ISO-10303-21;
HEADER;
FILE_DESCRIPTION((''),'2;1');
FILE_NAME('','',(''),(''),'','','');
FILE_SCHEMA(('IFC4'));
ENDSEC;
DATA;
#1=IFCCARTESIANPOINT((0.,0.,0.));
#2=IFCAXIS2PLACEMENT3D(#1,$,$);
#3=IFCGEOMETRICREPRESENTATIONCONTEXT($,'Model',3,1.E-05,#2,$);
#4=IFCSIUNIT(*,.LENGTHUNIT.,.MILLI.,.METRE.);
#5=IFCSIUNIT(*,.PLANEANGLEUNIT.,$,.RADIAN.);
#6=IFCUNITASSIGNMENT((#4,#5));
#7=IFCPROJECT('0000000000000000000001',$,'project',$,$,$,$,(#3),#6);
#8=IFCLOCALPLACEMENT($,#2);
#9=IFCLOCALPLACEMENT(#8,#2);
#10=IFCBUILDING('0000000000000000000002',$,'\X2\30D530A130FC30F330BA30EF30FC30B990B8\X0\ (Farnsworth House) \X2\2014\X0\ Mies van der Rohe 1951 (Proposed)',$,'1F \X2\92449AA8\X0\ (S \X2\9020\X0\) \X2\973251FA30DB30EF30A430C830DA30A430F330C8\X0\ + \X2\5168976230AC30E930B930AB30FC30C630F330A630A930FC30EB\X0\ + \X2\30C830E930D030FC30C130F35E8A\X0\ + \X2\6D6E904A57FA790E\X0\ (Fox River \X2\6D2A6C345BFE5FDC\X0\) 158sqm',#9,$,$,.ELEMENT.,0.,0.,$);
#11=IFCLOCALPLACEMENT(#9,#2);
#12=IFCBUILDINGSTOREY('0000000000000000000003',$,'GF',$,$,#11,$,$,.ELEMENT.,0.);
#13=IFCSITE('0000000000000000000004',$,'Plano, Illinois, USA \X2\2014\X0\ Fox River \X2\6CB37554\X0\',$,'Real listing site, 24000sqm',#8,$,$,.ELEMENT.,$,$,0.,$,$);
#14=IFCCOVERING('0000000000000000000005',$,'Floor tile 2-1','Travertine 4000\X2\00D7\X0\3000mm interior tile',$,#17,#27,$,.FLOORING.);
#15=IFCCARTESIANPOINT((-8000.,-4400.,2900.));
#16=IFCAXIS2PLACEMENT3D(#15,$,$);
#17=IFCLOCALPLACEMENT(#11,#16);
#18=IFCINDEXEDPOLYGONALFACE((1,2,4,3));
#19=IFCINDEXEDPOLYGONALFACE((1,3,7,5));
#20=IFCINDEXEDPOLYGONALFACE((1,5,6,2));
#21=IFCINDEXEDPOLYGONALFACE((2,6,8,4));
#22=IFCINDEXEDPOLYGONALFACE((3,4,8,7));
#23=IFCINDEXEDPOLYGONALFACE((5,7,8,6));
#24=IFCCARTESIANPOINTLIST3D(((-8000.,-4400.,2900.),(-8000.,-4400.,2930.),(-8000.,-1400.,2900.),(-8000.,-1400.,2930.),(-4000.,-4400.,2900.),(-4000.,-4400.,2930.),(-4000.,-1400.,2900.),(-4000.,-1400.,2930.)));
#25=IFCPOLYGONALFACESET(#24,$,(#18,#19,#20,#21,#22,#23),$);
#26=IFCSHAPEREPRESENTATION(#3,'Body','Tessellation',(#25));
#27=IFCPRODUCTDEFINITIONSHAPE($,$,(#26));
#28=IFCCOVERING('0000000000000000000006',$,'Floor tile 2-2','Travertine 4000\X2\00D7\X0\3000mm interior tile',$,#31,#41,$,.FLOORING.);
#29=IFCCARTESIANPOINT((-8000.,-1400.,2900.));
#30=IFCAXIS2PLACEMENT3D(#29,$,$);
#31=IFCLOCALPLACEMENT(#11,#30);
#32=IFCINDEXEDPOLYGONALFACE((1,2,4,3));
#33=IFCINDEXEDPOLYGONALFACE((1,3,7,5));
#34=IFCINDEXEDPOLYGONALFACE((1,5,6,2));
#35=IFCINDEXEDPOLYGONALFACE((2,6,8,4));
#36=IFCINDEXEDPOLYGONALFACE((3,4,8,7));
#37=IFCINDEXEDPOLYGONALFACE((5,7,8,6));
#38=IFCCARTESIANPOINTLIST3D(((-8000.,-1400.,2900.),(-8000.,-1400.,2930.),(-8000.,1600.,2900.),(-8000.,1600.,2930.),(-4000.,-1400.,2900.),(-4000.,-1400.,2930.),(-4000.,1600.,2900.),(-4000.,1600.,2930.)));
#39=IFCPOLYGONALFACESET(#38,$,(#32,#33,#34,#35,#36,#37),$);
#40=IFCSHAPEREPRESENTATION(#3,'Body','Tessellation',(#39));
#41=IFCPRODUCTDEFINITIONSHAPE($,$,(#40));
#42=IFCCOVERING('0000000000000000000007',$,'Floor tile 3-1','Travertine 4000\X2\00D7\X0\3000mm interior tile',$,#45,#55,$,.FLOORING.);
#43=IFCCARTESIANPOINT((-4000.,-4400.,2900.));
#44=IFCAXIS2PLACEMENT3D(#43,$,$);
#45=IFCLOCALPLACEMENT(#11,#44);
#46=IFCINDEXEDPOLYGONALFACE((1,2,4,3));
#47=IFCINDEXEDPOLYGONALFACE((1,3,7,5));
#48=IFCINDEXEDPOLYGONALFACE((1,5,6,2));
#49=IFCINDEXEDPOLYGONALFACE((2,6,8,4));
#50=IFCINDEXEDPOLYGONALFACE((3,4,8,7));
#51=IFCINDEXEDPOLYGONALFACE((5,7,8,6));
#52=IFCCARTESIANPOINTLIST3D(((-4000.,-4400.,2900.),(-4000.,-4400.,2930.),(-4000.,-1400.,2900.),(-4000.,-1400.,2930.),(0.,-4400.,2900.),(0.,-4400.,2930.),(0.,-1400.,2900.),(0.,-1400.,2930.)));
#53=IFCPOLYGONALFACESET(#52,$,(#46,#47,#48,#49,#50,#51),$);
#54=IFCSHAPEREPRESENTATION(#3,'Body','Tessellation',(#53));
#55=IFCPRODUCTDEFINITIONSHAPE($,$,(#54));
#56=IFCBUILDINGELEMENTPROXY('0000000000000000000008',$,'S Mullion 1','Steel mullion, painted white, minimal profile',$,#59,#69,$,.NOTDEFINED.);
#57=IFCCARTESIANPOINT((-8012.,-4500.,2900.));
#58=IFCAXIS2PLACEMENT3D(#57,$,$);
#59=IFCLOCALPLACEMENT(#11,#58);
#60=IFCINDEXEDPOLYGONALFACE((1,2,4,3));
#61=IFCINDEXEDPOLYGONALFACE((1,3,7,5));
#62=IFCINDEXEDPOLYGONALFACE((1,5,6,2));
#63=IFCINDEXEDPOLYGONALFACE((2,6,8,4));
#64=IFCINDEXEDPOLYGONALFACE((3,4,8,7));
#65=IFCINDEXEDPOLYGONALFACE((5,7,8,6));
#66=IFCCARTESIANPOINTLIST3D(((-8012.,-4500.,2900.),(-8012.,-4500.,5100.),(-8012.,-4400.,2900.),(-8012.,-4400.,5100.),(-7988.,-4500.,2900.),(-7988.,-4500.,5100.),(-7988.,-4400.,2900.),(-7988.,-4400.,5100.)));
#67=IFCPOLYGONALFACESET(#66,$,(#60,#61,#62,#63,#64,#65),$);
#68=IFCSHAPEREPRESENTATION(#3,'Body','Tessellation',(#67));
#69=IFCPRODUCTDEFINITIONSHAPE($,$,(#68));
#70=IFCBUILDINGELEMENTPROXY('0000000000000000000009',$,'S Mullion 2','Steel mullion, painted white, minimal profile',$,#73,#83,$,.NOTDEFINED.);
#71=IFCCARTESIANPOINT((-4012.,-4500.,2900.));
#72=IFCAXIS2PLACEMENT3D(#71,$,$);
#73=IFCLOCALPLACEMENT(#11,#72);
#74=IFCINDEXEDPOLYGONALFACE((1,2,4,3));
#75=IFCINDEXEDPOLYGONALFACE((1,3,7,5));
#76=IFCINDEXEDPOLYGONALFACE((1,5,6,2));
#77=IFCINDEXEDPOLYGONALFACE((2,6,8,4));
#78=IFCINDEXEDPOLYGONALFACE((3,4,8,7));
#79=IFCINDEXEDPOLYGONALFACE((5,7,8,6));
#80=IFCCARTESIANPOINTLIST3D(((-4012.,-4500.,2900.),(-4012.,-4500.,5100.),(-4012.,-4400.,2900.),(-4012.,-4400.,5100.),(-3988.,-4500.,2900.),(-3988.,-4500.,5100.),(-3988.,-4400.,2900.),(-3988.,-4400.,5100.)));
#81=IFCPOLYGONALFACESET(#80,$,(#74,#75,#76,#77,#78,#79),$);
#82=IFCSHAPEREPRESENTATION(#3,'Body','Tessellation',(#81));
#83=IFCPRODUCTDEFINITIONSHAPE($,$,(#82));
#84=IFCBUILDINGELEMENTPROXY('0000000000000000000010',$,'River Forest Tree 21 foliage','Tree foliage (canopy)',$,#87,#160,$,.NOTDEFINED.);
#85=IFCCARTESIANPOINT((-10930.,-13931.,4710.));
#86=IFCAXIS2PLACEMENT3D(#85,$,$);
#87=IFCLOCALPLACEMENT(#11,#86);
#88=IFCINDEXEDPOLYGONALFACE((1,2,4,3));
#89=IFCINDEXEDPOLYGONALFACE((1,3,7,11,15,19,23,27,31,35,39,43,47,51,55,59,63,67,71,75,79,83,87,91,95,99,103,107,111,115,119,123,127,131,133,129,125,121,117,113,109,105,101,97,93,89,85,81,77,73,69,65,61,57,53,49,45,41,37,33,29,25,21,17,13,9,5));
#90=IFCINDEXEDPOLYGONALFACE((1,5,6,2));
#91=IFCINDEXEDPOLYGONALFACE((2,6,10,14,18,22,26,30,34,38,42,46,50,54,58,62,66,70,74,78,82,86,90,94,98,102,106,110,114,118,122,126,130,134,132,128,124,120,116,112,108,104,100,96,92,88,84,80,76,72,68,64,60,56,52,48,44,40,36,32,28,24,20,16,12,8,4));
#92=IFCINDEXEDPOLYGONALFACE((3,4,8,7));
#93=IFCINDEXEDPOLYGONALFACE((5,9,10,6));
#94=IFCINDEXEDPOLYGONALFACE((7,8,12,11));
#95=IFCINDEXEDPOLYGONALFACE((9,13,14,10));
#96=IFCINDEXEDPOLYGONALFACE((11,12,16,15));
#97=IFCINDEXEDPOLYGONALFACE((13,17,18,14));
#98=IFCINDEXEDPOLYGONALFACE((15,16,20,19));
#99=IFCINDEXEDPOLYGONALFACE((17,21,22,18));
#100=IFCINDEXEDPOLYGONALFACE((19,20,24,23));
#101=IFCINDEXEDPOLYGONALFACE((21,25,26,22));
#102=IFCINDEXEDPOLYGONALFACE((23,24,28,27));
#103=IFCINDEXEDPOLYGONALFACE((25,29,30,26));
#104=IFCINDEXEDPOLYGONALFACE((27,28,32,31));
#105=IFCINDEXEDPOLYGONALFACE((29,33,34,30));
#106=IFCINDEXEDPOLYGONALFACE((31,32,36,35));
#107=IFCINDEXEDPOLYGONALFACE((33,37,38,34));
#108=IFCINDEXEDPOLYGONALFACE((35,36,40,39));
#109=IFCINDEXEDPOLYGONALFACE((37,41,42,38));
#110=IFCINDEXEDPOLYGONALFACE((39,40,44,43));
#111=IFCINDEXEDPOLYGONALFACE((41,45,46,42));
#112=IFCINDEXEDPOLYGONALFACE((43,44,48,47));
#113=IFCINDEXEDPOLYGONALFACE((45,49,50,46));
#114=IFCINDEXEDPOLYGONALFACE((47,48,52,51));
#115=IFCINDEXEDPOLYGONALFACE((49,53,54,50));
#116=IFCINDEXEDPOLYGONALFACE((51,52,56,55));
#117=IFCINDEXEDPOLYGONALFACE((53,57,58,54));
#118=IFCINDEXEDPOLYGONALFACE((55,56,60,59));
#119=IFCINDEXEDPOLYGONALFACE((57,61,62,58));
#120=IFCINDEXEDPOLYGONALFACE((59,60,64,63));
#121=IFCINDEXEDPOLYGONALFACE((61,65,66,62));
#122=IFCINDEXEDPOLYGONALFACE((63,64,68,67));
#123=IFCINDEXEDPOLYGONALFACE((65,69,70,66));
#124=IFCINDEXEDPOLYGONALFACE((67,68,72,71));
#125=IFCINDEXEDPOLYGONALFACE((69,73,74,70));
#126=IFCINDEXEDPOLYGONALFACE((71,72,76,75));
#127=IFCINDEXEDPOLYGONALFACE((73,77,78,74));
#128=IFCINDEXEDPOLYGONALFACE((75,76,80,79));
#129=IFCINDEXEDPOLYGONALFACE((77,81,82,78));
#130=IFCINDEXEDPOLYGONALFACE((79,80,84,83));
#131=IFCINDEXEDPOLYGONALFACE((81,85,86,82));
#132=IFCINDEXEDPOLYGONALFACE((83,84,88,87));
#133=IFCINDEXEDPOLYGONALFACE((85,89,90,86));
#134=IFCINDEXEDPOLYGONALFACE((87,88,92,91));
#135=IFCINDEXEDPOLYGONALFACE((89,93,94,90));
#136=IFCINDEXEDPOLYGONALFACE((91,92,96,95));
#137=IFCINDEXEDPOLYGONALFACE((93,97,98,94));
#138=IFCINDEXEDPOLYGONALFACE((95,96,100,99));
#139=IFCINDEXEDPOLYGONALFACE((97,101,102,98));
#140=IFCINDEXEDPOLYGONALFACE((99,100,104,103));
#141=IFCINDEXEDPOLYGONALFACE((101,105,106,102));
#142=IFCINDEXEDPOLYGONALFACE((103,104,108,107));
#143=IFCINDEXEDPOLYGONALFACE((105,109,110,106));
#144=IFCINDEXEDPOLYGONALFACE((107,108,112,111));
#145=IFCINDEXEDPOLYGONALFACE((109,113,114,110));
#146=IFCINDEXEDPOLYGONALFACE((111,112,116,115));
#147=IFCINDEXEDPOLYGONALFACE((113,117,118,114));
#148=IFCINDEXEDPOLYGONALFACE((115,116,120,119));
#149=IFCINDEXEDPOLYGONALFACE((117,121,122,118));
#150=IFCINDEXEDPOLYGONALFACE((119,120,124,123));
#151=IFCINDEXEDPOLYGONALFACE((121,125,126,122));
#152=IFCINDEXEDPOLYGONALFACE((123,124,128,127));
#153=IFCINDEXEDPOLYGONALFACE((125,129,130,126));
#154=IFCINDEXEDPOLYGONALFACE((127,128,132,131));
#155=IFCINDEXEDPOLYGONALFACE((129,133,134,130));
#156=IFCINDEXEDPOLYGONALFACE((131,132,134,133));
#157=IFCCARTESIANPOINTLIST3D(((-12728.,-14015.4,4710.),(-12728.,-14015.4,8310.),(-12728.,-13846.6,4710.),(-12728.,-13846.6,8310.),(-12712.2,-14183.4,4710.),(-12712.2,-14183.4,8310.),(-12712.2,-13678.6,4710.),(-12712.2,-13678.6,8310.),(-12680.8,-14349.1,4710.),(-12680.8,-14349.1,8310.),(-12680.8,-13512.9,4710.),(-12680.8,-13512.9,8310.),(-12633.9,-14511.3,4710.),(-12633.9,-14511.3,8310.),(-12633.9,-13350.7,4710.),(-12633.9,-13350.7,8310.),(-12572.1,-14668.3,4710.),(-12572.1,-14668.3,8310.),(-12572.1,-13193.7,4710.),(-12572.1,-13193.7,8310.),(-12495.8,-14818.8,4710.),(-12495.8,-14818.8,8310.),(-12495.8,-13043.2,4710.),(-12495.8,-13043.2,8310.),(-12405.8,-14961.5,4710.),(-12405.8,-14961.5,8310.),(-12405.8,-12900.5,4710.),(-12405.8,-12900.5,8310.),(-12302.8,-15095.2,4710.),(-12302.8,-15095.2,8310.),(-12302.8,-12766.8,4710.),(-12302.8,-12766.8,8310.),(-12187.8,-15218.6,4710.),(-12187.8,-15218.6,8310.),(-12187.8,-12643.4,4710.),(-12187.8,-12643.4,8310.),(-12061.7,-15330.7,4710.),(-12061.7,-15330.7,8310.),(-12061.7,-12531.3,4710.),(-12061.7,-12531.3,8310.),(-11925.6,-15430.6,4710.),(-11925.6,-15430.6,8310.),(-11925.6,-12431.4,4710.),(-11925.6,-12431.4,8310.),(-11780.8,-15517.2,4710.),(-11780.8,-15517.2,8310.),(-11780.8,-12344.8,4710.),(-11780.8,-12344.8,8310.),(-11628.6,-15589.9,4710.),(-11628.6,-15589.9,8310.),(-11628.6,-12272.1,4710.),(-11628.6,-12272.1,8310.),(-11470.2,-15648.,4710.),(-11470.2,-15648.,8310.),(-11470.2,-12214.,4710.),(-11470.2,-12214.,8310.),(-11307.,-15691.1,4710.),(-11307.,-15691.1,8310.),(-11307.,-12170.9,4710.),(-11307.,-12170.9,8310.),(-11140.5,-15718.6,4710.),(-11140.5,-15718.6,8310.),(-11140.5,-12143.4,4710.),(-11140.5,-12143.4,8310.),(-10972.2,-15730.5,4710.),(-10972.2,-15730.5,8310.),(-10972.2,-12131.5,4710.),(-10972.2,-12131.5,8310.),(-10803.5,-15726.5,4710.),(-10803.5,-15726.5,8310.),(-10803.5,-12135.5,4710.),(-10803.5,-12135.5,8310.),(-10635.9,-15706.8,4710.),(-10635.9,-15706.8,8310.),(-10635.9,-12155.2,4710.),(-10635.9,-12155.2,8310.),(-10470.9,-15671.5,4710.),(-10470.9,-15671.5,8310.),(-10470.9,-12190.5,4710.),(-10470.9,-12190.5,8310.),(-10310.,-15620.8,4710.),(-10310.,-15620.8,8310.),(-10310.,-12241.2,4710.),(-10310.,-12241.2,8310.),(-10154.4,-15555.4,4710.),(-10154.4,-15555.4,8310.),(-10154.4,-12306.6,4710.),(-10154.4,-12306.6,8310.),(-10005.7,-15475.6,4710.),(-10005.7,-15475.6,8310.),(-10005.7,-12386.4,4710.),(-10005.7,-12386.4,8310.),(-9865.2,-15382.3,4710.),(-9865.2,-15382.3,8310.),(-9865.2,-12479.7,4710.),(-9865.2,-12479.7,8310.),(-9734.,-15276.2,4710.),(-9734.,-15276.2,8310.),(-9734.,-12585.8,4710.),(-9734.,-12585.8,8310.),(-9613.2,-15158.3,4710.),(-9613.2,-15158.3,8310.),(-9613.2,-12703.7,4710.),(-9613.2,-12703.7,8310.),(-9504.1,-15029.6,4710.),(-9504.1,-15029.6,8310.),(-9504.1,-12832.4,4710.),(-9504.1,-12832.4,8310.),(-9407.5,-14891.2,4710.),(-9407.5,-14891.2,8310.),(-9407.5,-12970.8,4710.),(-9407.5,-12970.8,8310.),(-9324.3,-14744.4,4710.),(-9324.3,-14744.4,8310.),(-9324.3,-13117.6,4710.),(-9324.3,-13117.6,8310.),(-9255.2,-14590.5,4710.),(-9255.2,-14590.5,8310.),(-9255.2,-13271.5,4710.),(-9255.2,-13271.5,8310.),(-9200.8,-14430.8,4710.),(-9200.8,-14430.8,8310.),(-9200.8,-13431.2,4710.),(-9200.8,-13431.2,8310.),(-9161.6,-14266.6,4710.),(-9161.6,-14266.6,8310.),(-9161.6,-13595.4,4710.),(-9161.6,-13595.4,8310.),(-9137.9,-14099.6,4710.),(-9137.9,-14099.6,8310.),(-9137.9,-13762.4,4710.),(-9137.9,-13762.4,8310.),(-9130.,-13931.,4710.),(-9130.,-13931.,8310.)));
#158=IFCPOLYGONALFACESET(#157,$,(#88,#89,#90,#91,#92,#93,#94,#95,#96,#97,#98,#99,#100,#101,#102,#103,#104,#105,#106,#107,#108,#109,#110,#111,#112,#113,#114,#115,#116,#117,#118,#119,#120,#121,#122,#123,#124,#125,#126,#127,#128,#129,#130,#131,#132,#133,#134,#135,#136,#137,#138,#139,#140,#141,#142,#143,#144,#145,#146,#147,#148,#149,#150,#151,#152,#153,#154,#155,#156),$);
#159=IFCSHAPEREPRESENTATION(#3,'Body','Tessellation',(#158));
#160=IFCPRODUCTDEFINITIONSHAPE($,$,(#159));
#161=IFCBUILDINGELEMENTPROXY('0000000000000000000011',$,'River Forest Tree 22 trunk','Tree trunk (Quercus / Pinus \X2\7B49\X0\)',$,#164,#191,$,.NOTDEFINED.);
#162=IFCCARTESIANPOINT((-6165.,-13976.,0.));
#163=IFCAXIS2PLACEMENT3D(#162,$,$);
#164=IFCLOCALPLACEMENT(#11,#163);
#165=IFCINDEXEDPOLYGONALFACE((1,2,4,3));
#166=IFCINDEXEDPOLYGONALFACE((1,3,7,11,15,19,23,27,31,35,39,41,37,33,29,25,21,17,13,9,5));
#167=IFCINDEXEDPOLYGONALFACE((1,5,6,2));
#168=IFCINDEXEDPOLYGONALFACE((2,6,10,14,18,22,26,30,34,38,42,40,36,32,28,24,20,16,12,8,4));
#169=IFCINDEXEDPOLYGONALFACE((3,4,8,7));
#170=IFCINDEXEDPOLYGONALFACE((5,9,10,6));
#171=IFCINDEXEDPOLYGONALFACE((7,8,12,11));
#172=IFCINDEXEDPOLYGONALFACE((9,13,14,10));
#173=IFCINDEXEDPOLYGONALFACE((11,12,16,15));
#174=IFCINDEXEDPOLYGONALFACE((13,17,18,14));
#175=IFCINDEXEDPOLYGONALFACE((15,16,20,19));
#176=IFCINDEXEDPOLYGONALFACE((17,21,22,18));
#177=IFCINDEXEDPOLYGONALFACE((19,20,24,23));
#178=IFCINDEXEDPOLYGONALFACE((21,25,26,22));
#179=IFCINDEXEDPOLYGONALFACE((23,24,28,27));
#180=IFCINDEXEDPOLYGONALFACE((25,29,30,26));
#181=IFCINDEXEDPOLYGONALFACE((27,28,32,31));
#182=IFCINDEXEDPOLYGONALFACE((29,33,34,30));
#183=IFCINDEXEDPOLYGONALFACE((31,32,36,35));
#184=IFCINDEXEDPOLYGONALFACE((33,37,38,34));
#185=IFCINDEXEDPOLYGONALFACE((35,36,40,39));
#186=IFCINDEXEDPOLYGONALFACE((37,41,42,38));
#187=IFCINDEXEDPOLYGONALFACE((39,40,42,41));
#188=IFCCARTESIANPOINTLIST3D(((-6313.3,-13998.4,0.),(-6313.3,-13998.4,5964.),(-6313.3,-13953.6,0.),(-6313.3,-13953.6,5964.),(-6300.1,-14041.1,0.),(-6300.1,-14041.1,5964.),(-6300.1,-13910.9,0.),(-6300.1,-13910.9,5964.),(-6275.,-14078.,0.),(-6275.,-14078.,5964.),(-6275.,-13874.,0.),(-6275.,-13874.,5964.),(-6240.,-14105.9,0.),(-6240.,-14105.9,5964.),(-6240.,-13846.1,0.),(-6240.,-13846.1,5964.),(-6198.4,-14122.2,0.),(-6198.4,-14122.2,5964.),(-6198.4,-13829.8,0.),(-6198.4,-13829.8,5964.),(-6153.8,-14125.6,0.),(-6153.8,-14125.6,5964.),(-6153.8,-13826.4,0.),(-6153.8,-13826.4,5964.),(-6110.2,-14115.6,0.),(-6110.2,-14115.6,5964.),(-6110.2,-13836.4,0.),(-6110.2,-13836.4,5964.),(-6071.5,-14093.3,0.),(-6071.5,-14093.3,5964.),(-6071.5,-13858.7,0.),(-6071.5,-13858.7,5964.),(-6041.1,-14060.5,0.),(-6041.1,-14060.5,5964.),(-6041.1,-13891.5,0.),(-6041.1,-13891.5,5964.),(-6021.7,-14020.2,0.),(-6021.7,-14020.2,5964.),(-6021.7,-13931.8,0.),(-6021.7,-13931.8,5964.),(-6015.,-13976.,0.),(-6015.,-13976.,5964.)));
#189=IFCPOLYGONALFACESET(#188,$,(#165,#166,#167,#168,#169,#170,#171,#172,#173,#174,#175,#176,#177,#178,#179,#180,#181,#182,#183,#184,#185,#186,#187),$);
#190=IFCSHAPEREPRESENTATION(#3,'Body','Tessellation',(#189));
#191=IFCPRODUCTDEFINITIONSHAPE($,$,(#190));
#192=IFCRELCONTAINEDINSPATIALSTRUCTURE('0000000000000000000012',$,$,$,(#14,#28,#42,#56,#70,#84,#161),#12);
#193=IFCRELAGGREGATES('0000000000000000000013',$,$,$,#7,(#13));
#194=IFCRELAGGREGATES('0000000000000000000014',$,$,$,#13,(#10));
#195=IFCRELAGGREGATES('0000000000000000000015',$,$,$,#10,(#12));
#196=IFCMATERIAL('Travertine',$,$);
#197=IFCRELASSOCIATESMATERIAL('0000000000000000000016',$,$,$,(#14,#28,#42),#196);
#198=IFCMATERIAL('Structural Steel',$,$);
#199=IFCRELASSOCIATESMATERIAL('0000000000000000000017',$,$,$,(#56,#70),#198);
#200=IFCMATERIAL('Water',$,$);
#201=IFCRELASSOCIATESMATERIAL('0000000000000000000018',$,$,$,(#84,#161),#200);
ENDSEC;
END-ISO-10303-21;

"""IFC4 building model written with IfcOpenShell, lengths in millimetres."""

from ifc_helpers import new_model, si_unit, frame, frame_2d, origin, origin_2d, place, context, project, spatial, rectangle, circle, extrude, material, element, save


model = new_model("IFC4")

# Units and contexts
model_context = context("Model", 3, precision=1e-05, world=origin())
ifc_project = project(units=[si_unit("LENGTHUNIT", "METRE", prefix="MILLI"), si_unit("PLANEANGLEUNIT", "RADIAN")], contexts=[model_context])

# Site, building, storey
site_placement = place(None, origin())
site = spatial("IfcSite", under=ifc_project, at=site_placement, Name="Plano, Illinois, USA — Fox River 河畔", ObjectType="Real listing site, 24000sqm", CompositionType="ELEMENT", RefElevation=0.0)
building_placement = place(site_placement, origin())
building = spatial("IfcBuilding", under=site, at=building_placement, Name="ファーンズワース邸 (Farnsworth House) — Mies van der Rohe 1951 (Proposed)", ObjectType="1F 鉄骨 (S 造) 露出ホワイトペイント + 全面ガラスカーテンウォール + トラバーチン床 + 浮遊基礎 (Fox River 洪水対応) 158sqm", CompositionType="ELEMENT", ElevationOfRefHeight=0.0, ElevationOfTerrain=0.0)
storey_placement = place(building_placement, origin())
storey = spatial("IfcBuildingStorey", under=building, at=storey_placement, Name="GF", CompositionType="ELEMENT", Elevation=0.0)

# Shared definitions
ifc_material_1 = material(Name="Structural Steel")

# Coverings
ifc_material_2 = material(Name="Travertine")
covering_1_placement = place(storey_placement, frame((-8000.0, -4400.0, 2900.0)))
element("IfcCovering", 1, at=covering_1_placement, inside=storey, material=ifc_material_2, Name="Floor tile 2-1", Description="Travertine 4000×3000mm interior tile", PredefinedType="FLOORING", context=model_context, shape_type="SweptSolid", body=[
    extrude(rectangle(XDim=4000.0, YDim=3000.0, at=frame_2d((2000.0, 1500.0))), frame((-8000.0, -4400.0, 2900.0)), (0.0, 0.0, 1.0), 30.0),
])
covering_2_placement = place(storey_placement, frame((-8000.0, -1400.0, 2900.0)))
element("IfcCovering", 2, at=covering_2_placement, inside=storey, material=ifc_material_2, Name="Floor tile 2-2", Description="Travertine 4000×3000mm interior tile", PredefinedType="FLOORING", context=model_context, shape_type="SweptSolid", body=[
    extrude(rectangle(XDim=4000.0, YDim=3000.0, at=frame_2d((2000.0, 1500.0))), frame((-8000.0, -1400.0, 2900.0)), (0.0, 0.0, 1.0), 30.0),
])
covering_3_placement = place(storey_placement, frame((-4000.0, -4400.0, 2900.0)))
element("IfcCovering", 3, at=covering_3_placement, inside=storey, material=ifc_material_2, Name="Floor tile 3-1", Description="Travertine 4000×3000mm interior tile", PredefinedType="FLOORING", context=model_context, shape_type="SweptSolid", body=[
    extrude(rectangle(XDim=4000.0, YDim=3000.0, at=frame_2d((2000.0, 1500.0))), frame((-4000.0, -4400.0, 2900.0)), (0.0, 0.0, 1.0), 30.0),
])

# Building element proxies
proxy_1_placement = place(storey_placement, frame((-8012.0, -4500.0, 2900.0)))
element("IfcBuildingElementProxy", 4, at=proxy_1_placement, inside=storey, material=ifc_material_1, Name="S Mullion 1", Description="Steel mullion, painted white, minimal profile", PredefinedType="NOTDEFINED", context=model_context, shape_type="SweptSolid", body=[
    extrude(rectangle(XDim=24.0, YDim=100.0, at=frame_2d((12.0, 50.0))), frame((-8012.0, -4500.0, 2900.0)), (0.0, 0.0, 1.0), 2200.0),
])
proxy_2_placement = place(storey_placement, frame((-4012.0, -4500.0, 2900.0)))
element("IfcBuildingElementProxy", 5, at=proxy_2_placement, inside=storey, material=ifc_material_1, Name="S Mullion 2", Description="Steel mullion, painted white, minimal profile", PredefinedType="NOTDEFINED", context=model_context, shape_type="SweptSolid", body=[
    extrude(rectangle(XDim=24.0, YDim=100.0, at=frame_2d((12.0, 50.0))), frame((-4012.0, -4500.0, 2900.0)), (0.0, 0.0, 1.0), 2200.0),
])
ifc_material_3 = material(Name="Water")
proxy_3_placement = place(storey_placement, frame((-10930.0, -13931.0, 4710.0)))
element("IfcBuildingElementProxy", 6, at=proxy_3_placement, inside=storey, material=ifc_material_3, Name="River Forest Tree 21 foliage", Description="Tree foliage (canopy)", PredefinedType="NOTDEFINED", context=model_context, shape_type="SweptSolid", body=[
    extrude(circle(Radius=1800.0, at=origin_2d()), frame((-10930.0, -13931.0, 4710.0)), (0.0, 0.0, 1.0), 3600.0),
])
proxy_4_placement = place(storey_placement, frame((-6165.0, -13976.0, 0.0)))
element("IfcBuildingElementProxy", 7, at=proxy_4_placement, inside=storey, material=ifc_material_3, Name="River Forest Tree 22 trunk", Description="Tree trunk (Quercus / Pinus 等)", PredefinedType="NOTDEFINED", context=model_context, shape_type="SweptSolid", body=[
    extrude(circle(Radius=150.0, at=origin_2d()), frame((-6165.0, -13976.0, 0.0)), (0.0, 0.0, 1.0), 5964.0),
])

save(model, "model.ifc")
